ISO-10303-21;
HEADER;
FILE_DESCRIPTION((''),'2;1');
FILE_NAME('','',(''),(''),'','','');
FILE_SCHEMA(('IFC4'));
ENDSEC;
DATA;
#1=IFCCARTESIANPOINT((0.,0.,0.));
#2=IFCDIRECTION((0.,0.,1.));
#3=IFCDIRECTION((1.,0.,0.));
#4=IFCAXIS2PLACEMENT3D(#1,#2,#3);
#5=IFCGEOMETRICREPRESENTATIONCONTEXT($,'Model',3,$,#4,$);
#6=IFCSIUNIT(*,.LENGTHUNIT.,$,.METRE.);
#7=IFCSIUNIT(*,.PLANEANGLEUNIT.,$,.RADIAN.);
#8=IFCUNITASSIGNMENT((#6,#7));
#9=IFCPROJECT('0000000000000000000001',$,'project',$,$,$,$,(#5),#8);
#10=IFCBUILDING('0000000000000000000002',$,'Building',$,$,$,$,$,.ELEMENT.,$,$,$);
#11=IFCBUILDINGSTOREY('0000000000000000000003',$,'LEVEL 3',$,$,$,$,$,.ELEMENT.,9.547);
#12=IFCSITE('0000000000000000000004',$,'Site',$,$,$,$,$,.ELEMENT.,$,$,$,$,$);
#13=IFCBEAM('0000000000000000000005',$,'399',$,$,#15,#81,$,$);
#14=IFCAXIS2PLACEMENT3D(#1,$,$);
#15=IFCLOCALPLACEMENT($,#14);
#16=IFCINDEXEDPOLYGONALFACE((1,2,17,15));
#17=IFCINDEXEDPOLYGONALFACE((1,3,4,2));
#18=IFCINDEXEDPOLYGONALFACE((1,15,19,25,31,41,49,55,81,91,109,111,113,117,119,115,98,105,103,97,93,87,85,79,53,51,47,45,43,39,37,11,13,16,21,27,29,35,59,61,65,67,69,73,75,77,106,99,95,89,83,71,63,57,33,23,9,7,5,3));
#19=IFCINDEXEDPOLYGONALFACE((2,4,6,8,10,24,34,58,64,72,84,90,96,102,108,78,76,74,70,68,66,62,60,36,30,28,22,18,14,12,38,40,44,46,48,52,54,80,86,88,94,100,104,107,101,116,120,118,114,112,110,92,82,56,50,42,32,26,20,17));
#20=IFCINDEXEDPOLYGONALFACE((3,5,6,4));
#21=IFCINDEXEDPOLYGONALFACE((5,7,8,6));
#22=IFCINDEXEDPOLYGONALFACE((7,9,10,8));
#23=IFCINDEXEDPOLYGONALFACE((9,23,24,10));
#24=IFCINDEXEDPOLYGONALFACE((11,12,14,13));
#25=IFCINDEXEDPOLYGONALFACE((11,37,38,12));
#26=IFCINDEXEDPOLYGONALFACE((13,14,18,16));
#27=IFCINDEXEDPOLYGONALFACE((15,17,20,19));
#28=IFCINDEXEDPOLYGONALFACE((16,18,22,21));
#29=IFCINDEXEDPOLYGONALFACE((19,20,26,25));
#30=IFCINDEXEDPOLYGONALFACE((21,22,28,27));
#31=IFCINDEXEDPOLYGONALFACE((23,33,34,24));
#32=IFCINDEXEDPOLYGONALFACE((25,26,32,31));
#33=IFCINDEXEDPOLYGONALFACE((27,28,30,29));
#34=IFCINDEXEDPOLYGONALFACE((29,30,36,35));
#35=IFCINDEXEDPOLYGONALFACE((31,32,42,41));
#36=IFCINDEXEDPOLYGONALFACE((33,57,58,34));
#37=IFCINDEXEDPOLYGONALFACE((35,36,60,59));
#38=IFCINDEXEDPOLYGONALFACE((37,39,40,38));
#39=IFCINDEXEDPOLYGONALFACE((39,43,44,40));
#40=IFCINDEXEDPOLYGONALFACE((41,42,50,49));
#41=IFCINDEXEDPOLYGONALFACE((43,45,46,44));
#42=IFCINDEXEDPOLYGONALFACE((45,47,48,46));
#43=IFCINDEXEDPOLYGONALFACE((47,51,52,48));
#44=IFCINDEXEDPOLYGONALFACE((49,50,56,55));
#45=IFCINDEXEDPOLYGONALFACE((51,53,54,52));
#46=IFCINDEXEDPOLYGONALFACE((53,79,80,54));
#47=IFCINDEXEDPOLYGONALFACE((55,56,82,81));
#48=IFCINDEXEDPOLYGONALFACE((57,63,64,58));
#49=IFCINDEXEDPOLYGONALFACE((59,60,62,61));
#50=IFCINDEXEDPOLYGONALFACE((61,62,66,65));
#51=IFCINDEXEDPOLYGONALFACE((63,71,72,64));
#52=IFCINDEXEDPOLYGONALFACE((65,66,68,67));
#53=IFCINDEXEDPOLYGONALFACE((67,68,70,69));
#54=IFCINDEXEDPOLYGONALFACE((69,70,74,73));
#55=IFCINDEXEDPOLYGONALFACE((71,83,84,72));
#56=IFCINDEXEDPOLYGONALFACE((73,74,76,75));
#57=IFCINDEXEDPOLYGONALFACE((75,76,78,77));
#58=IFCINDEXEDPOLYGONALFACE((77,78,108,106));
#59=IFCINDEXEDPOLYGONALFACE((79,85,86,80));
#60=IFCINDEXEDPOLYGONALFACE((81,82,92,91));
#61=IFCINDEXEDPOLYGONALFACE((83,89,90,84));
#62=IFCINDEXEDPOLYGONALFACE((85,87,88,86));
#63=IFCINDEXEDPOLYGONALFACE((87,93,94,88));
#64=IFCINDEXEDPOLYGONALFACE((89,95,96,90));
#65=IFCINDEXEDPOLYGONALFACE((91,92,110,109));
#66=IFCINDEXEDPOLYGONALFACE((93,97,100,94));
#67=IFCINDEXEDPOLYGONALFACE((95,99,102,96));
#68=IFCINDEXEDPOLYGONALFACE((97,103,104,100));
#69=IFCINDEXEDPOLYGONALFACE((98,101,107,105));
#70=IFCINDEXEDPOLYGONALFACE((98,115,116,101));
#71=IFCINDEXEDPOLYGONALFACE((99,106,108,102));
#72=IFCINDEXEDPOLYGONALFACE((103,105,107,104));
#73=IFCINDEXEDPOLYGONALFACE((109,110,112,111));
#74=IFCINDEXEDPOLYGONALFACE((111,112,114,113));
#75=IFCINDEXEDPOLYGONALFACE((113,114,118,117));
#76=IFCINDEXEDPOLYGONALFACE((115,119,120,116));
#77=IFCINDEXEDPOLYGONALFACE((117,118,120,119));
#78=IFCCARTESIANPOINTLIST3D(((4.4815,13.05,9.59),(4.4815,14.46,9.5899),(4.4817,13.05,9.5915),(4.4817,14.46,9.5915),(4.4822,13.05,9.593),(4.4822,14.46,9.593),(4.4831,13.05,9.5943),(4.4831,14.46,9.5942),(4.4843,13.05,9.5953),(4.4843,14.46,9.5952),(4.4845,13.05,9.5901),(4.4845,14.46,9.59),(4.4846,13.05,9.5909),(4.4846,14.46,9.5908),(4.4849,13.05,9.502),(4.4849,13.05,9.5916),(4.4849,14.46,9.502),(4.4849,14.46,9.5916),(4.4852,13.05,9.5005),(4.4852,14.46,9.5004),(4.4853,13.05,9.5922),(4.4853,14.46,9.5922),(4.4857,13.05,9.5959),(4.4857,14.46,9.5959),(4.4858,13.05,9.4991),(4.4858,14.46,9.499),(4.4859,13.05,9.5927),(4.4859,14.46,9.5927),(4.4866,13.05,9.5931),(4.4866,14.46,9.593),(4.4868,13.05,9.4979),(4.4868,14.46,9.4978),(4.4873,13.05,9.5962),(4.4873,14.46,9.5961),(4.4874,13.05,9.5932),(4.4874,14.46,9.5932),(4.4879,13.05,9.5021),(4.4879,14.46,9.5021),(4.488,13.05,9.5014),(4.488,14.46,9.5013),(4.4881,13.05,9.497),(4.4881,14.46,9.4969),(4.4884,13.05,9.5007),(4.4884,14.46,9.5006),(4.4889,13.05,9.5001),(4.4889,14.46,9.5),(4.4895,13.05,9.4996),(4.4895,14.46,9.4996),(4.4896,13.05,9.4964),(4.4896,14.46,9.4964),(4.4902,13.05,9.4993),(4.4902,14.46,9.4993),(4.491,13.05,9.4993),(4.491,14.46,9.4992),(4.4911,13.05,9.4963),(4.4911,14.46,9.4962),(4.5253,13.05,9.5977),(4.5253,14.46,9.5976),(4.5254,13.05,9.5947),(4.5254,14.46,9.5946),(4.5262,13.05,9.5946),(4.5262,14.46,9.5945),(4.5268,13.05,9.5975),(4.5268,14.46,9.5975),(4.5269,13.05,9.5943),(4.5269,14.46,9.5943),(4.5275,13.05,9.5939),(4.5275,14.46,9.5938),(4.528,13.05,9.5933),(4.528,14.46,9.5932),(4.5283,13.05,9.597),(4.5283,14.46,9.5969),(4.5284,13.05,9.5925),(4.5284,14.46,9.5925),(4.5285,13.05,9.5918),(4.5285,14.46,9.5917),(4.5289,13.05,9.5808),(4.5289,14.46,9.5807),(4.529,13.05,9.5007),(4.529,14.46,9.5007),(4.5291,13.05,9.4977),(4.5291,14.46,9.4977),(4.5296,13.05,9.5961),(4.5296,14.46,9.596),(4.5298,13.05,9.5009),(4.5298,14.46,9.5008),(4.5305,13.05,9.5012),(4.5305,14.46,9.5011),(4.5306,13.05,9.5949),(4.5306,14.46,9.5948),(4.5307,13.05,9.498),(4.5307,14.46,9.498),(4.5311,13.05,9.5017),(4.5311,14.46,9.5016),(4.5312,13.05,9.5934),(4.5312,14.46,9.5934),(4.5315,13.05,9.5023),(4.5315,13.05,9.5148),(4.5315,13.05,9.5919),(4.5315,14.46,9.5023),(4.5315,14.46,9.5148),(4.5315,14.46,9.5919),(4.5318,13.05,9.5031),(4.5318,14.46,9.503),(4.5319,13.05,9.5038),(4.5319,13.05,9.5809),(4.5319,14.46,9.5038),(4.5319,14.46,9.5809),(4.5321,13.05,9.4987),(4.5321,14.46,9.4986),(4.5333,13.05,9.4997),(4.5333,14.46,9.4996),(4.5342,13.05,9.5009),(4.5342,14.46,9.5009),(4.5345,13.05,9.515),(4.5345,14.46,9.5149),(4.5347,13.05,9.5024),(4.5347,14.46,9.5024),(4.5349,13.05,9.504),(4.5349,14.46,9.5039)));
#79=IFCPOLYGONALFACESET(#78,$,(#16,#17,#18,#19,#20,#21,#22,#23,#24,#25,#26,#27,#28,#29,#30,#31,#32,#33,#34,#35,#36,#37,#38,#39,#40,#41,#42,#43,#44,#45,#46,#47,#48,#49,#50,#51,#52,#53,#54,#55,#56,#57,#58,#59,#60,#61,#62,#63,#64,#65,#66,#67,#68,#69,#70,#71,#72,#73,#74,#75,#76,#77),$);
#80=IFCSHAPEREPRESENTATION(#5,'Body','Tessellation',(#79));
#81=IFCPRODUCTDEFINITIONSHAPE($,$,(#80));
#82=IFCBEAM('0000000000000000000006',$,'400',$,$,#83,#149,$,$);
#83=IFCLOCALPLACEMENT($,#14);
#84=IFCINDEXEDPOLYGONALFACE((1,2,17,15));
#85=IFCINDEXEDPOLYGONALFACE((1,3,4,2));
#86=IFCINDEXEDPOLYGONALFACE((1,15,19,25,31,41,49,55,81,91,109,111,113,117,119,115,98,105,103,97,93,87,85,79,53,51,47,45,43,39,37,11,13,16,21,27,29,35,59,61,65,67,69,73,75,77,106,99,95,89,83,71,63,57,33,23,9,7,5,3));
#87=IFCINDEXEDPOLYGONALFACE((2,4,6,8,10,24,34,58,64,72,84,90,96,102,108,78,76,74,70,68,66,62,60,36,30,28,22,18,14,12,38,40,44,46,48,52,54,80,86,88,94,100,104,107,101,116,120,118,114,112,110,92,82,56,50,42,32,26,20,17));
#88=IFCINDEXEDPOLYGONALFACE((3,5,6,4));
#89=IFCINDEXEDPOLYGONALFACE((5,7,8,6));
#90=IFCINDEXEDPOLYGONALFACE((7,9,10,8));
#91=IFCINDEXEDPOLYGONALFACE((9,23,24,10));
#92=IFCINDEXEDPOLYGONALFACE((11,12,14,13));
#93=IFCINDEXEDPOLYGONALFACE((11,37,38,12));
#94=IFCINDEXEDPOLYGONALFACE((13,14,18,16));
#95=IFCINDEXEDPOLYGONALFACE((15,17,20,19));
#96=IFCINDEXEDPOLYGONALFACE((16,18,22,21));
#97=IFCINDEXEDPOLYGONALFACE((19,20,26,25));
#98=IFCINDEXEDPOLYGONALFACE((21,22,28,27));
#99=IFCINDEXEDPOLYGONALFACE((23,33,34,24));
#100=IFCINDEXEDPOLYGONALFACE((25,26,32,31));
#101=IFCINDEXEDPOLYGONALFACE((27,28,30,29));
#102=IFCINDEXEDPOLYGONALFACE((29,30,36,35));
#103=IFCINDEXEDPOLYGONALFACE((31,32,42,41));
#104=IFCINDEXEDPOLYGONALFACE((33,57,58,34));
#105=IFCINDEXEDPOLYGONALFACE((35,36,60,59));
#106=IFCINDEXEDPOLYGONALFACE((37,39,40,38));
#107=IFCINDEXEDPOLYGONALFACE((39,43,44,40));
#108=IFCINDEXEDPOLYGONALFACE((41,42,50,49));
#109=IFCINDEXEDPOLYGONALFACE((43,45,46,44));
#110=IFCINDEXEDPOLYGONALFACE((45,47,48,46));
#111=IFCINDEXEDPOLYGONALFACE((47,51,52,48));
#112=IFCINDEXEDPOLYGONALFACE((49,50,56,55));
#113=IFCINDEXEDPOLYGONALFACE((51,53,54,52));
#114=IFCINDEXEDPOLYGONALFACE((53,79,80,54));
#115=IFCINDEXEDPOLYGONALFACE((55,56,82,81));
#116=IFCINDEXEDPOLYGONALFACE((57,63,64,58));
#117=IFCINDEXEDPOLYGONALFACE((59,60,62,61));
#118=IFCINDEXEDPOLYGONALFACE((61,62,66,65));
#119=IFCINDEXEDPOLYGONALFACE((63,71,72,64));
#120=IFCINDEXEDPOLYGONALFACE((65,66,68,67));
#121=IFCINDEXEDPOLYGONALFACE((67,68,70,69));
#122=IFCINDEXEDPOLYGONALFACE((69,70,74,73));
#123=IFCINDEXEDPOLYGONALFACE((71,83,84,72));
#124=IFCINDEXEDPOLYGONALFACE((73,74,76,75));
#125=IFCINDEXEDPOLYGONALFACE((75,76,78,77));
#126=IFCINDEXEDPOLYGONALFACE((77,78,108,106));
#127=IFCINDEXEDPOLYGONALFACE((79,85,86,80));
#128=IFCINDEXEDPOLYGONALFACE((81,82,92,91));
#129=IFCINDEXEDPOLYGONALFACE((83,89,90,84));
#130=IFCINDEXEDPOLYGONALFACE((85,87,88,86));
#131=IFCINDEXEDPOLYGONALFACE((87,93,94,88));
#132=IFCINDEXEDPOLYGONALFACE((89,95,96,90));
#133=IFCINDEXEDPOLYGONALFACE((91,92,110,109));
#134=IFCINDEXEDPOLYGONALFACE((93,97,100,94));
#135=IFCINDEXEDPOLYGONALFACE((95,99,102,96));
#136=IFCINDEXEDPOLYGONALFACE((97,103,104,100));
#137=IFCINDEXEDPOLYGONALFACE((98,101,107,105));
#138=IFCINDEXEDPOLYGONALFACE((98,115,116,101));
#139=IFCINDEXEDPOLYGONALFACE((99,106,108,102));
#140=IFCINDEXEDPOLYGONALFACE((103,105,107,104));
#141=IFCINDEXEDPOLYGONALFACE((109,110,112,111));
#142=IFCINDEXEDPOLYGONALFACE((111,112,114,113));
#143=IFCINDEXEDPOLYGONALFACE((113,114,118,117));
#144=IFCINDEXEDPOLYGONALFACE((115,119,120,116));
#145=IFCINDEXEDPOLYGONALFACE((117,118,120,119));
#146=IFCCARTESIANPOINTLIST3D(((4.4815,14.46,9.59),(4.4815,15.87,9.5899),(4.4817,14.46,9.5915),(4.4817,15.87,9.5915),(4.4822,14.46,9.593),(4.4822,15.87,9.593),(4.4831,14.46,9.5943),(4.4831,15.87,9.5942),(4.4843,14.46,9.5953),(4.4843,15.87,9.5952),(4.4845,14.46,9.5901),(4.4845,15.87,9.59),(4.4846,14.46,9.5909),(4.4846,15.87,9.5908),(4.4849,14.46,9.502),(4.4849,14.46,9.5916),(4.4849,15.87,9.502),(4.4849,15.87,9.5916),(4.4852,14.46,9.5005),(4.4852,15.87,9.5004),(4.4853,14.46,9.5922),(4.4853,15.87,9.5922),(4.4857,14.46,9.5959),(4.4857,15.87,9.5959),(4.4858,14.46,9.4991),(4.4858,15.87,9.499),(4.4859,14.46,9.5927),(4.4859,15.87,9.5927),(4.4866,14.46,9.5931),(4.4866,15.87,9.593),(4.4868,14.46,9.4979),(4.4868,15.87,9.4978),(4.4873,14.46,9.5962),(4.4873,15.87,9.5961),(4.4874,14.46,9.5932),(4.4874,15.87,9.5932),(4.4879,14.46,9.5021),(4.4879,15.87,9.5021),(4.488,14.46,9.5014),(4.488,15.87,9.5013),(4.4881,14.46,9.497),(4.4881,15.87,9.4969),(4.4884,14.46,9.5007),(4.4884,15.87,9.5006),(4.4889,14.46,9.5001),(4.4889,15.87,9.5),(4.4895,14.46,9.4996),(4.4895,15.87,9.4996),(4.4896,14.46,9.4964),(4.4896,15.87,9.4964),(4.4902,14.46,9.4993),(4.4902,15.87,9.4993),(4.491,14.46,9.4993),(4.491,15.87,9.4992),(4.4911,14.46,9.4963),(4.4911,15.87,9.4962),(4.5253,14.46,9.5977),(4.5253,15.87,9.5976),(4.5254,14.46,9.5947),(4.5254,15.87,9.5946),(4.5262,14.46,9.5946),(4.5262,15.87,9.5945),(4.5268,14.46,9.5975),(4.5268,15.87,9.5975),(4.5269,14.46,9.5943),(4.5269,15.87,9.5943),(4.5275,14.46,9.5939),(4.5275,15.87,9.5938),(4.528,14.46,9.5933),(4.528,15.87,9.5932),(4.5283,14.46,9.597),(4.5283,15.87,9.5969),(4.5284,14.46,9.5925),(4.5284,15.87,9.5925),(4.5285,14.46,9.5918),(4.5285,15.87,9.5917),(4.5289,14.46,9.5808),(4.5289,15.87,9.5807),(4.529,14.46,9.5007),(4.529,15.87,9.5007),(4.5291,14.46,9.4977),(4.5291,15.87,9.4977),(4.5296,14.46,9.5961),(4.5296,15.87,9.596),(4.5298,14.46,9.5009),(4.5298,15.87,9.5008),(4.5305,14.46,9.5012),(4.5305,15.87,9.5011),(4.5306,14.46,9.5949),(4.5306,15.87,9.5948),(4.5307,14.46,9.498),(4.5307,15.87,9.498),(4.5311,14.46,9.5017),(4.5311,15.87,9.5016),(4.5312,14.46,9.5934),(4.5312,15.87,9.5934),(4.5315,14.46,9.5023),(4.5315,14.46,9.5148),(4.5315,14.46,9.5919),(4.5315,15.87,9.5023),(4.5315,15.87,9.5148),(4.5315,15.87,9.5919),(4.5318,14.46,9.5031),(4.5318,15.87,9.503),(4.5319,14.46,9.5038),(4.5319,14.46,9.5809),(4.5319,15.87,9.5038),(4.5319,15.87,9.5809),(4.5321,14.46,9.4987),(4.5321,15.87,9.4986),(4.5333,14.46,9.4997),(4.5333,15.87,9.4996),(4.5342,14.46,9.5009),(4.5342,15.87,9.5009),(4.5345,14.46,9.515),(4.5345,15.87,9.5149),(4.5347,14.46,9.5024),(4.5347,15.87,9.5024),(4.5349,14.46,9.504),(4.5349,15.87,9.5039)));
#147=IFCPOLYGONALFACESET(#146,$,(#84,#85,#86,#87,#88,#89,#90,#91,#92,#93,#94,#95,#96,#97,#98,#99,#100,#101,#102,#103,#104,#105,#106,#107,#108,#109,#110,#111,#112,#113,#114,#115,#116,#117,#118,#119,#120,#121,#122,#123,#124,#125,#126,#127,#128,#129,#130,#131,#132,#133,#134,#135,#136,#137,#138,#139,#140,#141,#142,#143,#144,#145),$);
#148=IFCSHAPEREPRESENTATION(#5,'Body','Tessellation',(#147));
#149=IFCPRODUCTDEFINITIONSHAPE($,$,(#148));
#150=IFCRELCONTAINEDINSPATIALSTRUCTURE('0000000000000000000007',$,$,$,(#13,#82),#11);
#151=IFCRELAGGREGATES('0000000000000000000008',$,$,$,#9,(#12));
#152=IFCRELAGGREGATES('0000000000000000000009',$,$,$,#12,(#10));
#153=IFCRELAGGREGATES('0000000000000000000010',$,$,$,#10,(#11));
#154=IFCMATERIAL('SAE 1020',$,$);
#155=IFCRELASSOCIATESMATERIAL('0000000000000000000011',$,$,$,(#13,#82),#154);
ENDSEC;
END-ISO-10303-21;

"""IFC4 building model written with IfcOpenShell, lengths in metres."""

from ifc_helpers import new_model, si_unit, frame, origin_with_axes, origin_2d_with_axis, place, context, project, spatial, c_section, extrude, material, material_profile, profile_set, profile_usage, element, save


model = new_model("IFC4")

# Units and contexts
model_context = context("Model", 3, world=origin_with_axes())
ifc_project = project(units=[si_unit("LENGTHUNIT", "METRE"), si_unit("PLANEANGLEUNIT", "RADIAN")], contexts=[model_context])

# Site, building, storey
site = spatial("IfcSite", under=ifc_project, Name="Site", CompositionType="ELEMENT")
building = spatial("IfcBuilding", under=site, Name="Building", CompositionType="ELEMENT")
storey = spatial("IfcBuildingStorey", under=building, Name="LEVEL 3", CompositionType="ELEMENT", Elevation=9.547)

# Beams
ifc_material = material(Name="SAE 1020")
ifc_material_profile_1 = material_profile(ifc_material, c_section(Depth=0.1, Width=0.05, WallThickness=0.003, Girth=0.017, InternalFilletRadius=0.003, at=origin_2d_with_axis()))
ifc_profile_set_1 = profile_set([ifc_material_profile_1])
ifc_profile_usage_1 = profile_usage(ifc_profile_set_1, cardinal=10)
beam_1_placement = place(None, frame((4.5082, 13.05, 9.547), z_axis=(0.0, 1.0, -0.00003), x_axis=(0.999256, 0.000001, 0.038562)))
element("IfcBeam", 1, at=beam_1_placement, inside=storey, material=ifc_profile_usage_1, Name="399", context=model_context, shape_type="SweptSolid", body=[
    extrude(c_section(Depth=0.1, Width=0.05, WallThickness=0.003, Girth=0.017, InternalFilletRadius=0.003, at=origin_2d_with_axis()), origin_with_axes(), (0.0, 0.0, 1.0), 1.41),
])
ifc_material_profile_2 = material_profile(ifc_material, c_section(Depth=0.1, Width=0.05, WallThickness=0.003, Girth=0.017, InternalFilletRadius=0.003, at=origin_2d_with_axis()))
ifc_profile_set_2 = profile_set([ifc_material_profile_2])
ifc_profile_usage_2 = profile_usage(ifc_profile_set_2, cardinal=10)
beam_2_placement = place(None, frame((4.5082, 14.46, 9.547), z_axis=(0.0, 1.0, -0.00003), x_axis=(0.999256, 0.000001, 0.038562)))
element("IfcBeam", 2, at=beam_2_placement, inside=storey, material=ifc_profile_usage_2, Name="400", context=model_context, shape_type="SweptSolid", body=[
    extrude(c_section(Depth=0.1, Width=0.05, WallThickness=0.003, Girth=0.017, InternalFilletRadius=0.003, at=origin_2d_with_axis()), origin_with_axes(), (0.0, 0.0, 1.0), 1.41),
])

save(model, "model.ifc")
